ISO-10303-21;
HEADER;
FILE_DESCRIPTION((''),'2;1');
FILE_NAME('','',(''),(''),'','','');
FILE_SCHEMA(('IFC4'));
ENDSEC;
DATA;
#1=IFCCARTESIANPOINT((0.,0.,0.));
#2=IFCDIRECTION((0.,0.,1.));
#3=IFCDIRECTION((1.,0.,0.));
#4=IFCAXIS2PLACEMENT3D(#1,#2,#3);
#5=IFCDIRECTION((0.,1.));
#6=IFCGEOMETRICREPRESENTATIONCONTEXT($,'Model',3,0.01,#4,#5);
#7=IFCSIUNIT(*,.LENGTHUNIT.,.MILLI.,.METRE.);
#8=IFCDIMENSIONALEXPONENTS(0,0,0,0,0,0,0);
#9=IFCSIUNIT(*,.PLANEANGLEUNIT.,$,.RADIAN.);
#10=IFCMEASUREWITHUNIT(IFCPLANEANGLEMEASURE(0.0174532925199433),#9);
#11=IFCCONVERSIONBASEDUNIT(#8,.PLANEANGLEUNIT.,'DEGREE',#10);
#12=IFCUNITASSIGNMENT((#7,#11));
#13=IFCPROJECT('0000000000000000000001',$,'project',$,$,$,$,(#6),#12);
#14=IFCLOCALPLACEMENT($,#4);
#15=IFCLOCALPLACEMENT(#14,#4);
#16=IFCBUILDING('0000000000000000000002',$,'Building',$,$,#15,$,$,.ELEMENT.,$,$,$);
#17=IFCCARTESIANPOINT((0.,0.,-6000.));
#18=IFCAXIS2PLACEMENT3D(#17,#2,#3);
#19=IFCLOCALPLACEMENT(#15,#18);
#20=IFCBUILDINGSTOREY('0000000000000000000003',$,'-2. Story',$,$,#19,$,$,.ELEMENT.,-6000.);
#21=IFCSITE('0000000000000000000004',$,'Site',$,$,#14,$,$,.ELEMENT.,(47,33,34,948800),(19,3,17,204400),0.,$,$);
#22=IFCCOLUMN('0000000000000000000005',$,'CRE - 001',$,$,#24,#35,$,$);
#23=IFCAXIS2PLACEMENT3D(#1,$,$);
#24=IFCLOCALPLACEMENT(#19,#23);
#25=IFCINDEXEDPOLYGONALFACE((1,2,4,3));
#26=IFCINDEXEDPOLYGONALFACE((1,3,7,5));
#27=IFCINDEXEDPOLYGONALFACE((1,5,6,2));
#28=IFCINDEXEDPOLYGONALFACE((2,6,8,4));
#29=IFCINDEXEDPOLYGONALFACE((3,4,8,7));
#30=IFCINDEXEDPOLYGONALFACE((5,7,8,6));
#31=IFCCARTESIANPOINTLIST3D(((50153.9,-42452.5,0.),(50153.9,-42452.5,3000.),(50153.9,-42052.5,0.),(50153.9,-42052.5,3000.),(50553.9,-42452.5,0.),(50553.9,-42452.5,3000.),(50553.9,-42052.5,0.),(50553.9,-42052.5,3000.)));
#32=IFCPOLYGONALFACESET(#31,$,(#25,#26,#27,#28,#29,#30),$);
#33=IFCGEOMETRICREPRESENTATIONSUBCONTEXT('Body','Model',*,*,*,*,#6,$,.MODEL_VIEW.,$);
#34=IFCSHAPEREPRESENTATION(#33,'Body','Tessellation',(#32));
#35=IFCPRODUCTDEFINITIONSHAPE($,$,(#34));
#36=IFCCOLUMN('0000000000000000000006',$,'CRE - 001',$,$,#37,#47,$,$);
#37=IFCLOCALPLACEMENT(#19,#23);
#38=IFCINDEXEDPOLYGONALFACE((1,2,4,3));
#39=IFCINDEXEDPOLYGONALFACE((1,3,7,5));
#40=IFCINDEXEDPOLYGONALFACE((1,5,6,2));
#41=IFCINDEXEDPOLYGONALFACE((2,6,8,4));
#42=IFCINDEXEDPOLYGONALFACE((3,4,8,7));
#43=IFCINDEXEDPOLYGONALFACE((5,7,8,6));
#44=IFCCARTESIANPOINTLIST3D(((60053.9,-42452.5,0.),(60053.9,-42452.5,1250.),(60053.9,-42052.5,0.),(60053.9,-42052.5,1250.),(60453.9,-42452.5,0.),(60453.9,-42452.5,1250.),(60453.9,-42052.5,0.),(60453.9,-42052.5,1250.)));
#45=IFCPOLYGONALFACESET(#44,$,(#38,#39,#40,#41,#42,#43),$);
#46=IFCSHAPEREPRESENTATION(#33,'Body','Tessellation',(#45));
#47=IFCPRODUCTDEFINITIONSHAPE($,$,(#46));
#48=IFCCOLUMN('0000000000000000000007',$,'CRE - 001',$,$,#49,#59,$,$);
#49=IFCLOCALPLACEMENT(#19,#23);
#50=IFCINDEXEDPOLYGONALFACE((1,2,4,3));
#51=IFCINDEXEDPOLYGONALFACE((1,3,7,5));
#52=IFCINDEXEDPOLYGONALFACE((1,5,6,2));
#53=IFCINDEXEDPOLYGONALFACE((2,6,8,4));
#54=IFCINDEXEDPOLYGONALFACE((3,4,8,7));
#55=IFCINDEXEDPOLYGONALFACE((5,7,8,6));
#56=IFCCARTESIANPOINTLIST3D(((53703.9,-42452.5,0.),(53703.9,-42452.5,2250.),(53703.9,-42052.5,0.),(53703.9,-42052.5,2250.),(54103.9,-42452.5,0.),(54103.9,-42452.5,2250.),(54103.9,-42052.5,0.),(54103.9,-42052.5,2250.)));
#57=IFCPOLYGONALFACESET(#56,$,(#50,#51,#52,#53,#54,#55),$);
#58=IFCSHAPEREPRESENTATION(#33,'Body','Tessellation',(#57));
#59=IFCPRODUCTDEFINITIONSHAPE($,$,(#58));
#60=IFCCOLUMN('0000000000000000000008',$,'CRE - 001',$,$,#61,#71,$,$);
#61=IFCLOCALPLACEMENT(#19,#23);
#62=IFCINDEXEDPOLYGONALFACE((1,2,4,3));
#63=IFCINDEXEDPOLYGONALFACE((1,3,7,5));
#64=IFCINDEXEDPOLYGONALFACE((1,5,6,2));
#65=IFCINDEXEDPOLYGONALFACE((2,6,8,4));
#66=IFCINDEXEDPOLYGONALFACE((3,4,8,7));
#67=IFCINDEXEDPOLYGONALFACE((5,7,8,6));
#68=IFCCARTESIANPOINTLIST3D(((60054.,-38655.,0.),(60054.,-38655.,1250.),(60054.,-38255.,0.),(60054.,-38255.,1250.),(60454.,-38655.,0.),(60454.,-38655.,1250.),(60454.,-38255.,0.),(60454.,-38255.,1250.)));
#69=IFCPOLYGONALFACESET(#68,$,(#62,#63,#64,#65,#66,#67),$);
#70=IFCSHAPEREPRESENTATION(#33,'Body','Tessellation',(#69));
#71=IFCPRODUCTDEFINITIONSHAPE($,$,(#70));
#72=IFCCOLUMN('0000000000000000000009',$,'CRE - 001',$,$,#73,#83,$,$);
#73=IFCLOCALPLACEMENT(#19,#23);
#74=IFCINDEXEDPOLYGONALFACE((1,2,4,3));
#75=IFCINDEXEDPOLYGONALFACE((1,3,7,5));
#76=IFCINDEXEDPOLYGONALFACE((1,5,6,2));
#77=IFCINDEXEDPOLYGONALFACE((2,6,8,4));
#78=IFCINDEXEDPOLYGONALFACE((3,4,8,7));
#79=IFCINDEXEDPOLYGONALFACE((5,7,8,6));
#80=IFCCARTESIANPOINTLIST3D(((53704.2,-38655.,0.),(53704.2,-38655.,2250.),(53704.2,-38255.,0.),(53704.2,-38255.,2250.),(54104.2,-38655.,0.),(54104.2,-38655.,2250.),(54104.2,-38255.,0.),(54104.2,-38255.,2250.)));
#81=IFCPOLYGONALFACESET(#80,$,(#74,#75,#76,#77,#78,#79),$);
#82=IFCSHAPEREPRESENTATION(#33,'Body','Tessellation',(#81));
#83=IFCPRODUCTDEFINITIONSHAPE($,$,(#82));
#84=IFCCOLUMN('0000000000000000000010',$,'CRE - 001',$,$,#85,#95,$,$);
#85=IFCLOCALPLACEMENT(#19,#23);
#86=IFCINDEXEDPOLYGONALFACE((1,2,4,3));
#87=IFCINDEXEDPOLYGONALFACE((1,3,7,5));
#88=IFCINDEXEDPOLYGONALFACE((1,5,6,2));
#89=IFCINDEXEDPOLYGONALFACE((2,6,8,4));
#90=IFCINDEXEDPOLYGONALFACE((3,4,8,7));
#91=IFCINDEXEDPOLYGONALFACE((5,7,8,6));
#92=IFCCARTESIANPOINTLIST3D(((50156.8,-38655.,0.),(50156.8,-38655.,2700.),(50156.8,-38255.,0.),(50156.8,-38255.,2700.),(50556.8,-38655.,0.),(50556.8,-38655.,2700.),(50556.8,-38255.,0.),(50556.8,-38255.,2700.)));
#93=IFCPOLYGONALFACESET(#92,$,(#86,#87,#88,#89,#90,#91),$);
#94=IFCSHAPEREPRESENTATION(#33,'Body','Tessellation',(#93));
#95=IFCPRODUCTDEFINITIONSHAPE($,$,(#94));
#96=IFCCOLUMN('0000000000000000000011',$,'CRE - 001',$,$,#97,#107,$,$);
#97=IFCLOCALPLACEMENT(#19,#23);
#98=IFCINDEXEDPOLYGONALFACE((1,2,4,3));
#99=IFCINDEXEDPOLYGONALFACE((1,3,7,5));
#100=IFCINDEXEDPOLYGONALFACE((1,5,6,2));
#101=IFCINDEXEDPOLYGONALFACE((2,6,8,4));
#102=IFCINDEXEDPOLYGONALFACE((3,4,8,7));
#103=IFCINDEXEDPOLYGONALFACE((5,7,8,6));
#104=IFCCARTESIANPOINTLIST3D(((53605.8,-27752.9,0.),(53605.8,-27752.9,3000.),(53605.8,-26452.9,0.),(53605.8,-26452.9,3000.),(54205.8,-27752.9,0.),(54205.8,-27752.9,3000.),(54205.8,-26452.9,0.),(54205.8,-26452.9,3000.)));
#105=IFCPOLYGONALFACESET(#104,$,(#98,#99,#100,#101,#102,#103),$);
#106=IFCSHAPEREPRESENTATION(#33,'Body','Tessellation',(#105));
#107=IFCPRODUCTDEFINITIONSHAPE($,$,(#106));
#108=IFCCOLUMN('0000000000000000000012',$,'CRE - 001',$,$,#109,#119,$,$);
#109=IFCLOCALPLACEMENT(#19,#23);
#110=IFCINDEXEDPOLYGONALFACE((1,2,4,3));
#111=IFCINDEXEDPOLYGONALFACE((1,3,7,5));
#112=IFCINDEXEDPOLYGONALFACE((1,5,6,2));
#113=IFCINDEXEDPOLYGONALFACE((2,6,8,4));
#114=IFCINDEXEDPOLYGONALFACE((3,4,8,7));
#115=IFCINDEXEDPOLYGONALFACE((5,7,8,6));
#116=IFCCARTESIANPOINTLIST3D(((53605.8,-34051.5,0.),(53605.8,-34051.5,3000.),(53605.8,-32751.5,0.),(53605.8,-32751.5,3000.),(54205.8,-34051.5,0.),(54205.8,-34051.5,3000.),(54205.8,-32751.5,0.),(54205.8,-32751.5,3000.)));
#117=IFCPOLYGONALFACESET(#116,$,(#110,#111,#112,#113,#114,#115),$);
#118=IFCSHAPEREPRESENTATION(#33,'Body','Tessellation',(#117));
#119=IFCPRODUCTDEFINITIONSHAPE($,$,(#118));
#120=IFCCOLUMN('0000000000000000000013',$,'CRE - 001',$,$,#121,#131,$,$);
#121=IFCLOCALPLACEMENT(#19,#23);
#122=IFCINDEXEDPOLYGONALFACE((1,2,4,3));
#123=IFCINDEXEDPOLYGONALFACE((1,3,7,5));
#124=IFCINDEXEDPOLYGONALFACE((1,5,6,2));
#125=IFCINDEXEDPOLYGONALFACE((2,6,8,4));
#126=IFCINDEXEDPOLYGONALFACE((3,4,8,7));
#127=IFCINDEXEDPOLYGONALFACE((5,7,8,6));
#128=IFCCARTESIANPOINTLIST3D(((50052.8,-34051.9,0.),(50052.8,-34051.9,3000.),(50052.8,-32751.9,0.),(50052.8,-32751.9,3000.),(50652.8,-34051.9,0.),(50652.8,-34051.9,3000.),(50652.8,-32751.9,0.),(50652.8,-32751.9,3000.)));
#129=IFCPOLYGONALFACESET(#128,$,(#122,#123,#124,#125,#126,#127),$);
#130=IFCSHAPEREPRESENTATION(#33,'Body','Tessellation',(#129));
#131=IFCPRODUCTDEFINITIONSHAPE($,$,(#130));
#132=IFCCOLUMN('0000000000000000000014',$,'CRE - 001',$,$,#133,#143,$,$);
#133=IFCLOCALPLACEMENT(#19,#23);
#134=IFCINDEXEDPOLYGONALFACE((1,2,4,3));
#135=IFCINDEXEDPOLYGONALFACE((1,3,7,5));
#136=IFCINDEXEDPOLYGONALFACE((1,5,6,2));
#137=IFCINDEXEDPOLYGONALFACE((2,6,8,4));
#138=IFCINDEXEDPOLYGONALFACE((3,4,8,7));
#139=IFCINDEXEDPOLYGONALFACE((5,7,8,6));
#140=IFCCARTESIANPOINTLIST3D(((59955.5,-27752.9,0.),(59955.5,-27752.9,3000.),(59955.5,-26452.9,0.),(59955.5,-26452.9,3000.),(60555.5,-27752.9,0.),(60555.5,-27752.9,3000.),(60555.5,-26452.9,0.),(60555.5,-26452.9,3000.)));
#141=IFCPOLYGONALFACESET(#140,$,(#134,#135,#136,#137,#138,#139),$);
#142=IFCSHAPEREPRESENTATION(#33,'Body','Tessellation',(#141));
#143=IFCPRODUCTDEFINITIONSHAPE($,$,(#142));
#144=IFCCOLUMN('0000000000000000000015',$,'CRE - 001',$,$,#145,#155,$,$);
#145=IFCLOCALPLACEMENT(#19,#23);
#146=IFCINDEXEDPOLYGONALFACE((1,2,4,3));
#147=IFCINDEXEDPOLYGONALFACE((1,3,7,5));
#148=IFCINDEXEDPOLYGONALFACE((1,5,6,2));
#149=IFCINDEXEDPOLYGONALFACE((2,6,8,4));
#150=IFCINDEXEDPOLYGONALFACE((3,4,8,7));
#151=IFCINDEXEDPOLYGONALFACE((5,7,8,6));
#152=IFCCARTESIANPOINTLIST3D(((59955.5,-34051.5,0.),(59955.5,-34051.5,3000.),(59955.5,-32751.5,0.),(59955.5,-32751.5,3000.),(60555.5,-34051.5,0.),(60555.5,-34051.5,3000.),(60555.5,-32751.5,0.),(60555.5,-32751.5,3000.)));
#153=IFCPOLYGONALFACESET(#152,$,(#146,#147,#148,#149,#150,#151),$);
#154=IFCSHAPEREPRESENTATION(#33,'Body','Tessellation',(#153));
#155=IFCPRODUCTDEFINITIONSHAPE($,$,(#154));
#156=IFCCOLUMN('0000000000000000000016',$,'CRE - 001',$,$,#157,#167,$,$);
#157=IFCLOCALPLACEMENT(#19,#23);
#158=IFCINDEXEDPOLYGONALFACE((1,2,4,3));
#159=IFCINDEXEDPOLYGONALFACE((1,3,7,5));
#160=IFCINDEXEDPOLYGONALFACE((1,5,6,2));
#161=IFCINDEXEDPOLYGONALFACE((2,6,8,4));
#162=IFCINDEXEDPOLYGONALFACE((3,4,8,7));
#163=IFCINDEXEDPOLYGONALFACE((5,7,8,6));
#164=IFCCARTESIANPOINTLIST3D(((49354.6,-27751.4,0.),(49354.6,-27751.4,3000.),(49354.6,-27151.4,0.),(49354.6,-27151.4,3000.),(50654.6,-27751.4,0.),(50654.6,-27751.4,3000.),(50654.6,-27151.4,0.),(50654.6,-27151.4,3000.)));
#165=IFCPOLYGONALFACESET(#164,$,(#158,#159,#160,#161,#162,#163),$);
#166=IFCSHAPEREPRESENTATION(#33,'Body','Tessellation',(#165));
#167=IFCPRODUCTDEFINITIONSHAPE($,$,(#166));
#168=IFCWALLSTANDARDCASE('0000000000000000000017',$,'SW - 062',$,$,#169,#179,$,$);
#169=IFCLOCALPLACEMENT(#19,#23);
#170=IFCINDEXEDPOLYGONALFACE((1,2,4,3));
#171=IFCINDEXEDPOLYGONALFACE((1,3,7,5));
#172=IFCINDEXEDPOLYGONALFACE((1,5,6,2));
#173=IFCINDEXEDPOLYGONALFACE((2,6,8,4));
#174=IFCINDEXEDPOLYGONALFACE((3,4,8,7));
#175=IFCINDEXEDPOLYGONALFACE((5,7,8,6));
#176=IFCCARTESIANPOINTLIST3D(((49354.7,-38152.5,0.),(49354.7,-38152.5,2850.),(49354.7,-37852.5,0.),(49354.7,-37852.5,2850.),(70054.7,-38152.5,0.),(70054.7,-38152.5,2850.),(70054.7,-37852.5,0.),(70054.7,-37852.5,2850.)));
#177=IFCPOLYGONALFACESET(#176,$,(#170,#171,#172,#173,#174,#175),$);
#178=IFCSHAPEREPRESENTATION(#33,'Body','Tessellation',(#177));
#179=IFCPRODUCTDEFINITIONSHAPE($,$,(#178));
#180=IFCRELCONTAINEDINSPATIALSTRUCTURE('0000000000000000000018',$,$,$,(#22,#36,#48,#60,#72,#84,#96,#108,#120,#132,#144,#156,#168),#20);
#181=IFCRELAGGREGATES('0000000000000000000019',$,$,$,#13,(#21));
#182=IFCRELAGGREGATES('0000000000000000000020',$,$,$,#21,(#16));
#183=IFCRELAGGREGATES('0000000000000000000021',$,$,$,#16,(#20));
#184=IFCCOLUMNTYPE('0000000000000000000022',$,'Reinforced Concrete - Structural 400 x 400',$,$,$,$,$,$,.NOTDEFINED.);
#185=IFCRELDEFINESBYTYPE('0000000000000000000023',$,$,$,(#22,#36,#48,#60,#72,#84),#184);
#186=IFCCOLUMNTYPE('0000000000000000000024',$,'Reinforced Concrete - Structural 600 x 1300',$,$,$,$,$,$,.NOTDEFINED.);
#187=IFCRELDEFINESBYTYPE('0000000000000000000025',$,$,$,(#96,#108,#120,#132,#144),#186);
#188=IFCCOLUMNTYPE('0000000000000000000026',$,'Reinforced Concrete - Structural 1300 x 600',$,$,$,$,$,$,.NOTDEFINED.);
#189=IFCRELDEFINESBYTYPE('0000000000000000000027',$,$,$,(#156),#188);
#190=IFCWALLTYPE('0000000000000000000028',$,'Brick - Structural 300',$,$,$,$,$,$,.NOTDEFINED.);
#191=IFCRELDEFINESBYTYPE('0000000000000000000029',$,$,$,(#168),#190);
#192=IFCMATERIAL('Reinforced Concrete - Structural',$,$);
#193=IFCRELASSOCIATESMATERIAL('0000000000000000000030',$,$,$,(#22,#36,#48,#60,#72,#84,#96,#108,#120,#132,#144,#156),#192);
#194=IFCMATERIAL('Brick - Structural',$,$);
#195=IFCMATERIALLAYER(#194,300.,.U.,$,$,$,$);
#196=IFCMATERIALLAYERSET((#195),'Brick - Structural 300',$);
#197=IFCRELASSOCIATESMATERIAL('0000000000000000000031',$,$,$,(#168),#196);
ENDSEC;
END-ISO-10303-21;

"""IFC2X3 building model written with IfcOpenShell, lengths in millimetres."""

from ifc_helpers import new_model, entity, si_unit, converted_unit, direction, frame, origin_with_axes, origin_2d_with_axis, place, context, subcontext, project, spatial, polyline, rectangle, outline, extrude, material, layer, layer_set, layer_usage, type_object, element, save


model = new_model("IFC2X3")

# Units and contexts
model_context = context("Model", 3, precision=0.01, world=origin_with_axes(), true_north=direction((0.0, 1.0)))
body_context = subcontext(model_context, "Body", "Model", "MODEL_VIEW")
ifc_project = project(units=[si_unit("LENGTHUNIT", "METRE", prefix="MILLI"), converted_unit("PLANEANGLEUNIT", "DEGREE", entity("IfcPlaneAngleMeasure", 0.0174532925199433), si_unit("PLANEANGLEUNIT", "RADIAN"), dimensions=[0, 0, 0, 0, 0, 0, 0])], contexts=[model_context])

# Site, building, storey
site_placement = place(None, origin_with_axes())
site = spatial("IfcSite", under=ifc_project, at=site_placement, Name="Site", CompositionType="ELEMENT", RefLatitude=(47, 33, 34, 948800), RefLongitude=(19, 3, 17, 204400), RefElevation=0.0)
building_placement = place(site_placement, origin_with_axes())
building = spatial("IfcBuilding", under=site, at=building_placement, Name="Building", CompositionType="ELEMENT")
storey_placement = place(building_placement, frame((0.0, 0.0, -6000.0), z_axis=(0.0, 0.0, 1.0), x_axis=(1.0, 0.0, 0.0)))
storey = spatial("IfcBuildingStorey", under=building, at=storey_placement, Name="-2. Story", CompositionType="ELEMENT", Elevation=-6000.0)

# Columns
ifc_material_1 = material(Name="Reinforced Concrete - Structural")
column_type_1 = type_object("IfcColumnType", Name="Reinforced Concrete - Structural 400 x 400", PredefinedType="NOTDEFINED")
column_1_placement = place(storey_placement, frame((50353.9, -42252.5, 0.0), z_axis=(0.0, 0.0, 1.0), x_axis=(1.0, 0.0, 0.0)))
element("IfcColumn", 1, at=column_1_placement, inside=storey, type_object=column_type_1, material=ifc_material_1, Name="CRE - 001", context=body_context, shape_type="SweptSolid", body=[
    extrude(rectangle(XDim=400.0, YDim=400.0, at=origin_2d_with_axis()), origin_with_axes(), (0.0, 0.0, 1.0), 3000.0),
])
column_2_placement = place(storey_placement, frame((60253.9, -42252.5, 0.0), z_axis=(0.0, 0.0, 1.0), x_axis=(1.0, 0.0, 0.0)))
element("IfcColumn", 2, at=column_2_placement, inside=storey, type_object=column_type_1, material=ifc_material_1, Name="CRE - 001", context=body_context, shape_type="SweptSolid", body=[
    extrude(rectangle(XDim=400.0, YDim=400.0, at=origin_2d_with_axis()), origin_with_axes(), (0.0, 0.0, 1.0), 1250.0),
])
column_3_placement = place(storey_placement, frame((53903.9, -42252.5, 0.0), z_axis=(0.0, 0.0, 1.0), x_axis=(1.0, 0.0, 0.0)))
element("IfcColumn", 3, at=column_3_placement, inside=storey, type_object=column_type_1, material=ifc_material_1, Name="CRE - 001", context=body_context, shape_type="SweptSolid", body=[
    extrude(rectangle(XDim=400.0, YDim=400.0, at=origin_2d_with_axis()), origin_with_axes(), (0.0, 0.0, 1.0), 2250.0),
])
column_4_placement = place(storey_placement, frame((60254.0, -38455.0, 0.0), z_axis=(0.0, 0.0, 1.0), x_axis=(1.0, 0.0, 0.0)))
element("IfcColumn", 4, at=column_4_placement, inside=storey, type_object=column_type_1, material=ifc_material_1, Name="CRE - 001", context=body_context, shape_type="SweptSolid", body=[
    extrude(rectangle(XDim=400.0, YDim=400.0, at=origin_2d_with_axis()), origin_with_axes(), (0.0, 0.0, 1.0), 1250.0),
])
column_5_placement = place(storey_placement, frame((53904.2, -38455.0, 0.0), z_axis=(0.0, 0.0, 1.0), x_axis=(1.0, 0.0, 0.0)))
element("IfcColumn", 5, at=column_5_placement, inside=storey, type_object=column_type_1, material=ifc_material_1, Name="CRE - 001", context=body_context, shape_type="SweptSolid", body=[
    extrude(rectangle(XDim=400.0, YDim=400.0, at=origin_2d_with_axis()), origin_with_axes(), (0.0, 0.0, 1.0), 2250.0),
])
column_6_placement = place(storey_placement, frame((50356.8, -38455.0, 0.0), z_axis=(0.0, 0.0, 1.0), x_axis=(1.0, 0.0, 0.0)))
element("IfcColumn", 6, at=column_6_placement, inside=storey, type_object=column_type_1, material=ifc_material_1, Name="CRE - 001", context=body_context, shape_type="SweptSolid", body=[
    extrude(rectangle(XDim=400.0, YDim=400.0, at=origin_2d_with_axis()), origin_with_axes(), (0.0, 0.0, 1.0), 2700.0),
])
column_type_2 = type_object("IfcColumnType", Name="Reinforced Concrete - Structural 600 x 1300", PredefinedType="NOTDEFINED")
for number, where, z_axis, x_axis, name in (
    (7, (53905.8, -27102.9, 0.0), (0.0, 0.0, 1.0), (1.0, 0.0, 0.0), "CRE - 001"),
    (8, (53905.8, -33401.5, 0.0), (0.0, 0.0, 1.0), (1.0, 0.0, 0.0), "CRE - 001"),
    (9, (50352.8, -33401.9, 0.0), (0.0, 0.0, 1.0), (1.0, 0.0, 0.0), "CRE - 001"),
    (10, (60255.5, -27102.9, 0.0), (0.0, 0.0, 1.0), (1.0, 0.0, 0.0), "CRE - 001"),
    (11, (60255.5, -33401.5, 0.0), (0.0, 0.0, 1.0), (1.0, 0.0, 0.0), "CRE - 001"),
):
    element("IfcColumn", number, at=place(storey_placement, frame(where, z_axis=z_axis, x_axis=x_axis)), inside=storey, type_object=column_type_2, material=ifc_material_1, Name=name, context=body_context, shape_type="SweptSolid", body=[
        extrude(rectangle(XDim=600.0, YDim=1300.0, at=origin_2d_with_axis()), origin_with_axes(), (0.0, 0.0, 1.0), 3000.0),
    ])
column_type_3 = type_object("IfcColumnType", Name="Reinforced Concrete - Structural 1300 x 600", PredefinedType="NOTDEFINED")
column_7_placement = place(storey_placement, frame((50004.6, -27451.4, 0.0), z_axis=(0.0, 0.0, 1.0), x_axis=(1.0, 0.0, 0.0)))
element("IfcColumn", 12, at=column_7_placement, inside=storey, type_object=column_type_3, material=ifc_material_1, Name="CRE - 001", context=body_context, shape_type="SweptSolid", body=[
    extrude(rectangle(XDim=1300.0, YDim=600.0, at=origin_2d_with_axis()), origin_with_axes(), (0.0, 0.0, 1.0), 3000.0),
])

# Wall
ifc_material_2 = material(Name="Brick - Structural")
ifc_layer_1 = layer(ifc_material_2, 300.0, ventilated="UNKNOWN")
ifc_layer_set_1 = layer_set([ifc_layer_1], Name="Brick - Structural 300")
ifc_layer_usage_1 = layer_usage(ifc_layer_set_1, "AXIS2", "POSITIVE", 0.0)
wall_type_1 = type_object("IfcWallType", Name="Brick - Structural 300", PredefinedType="NOTDEFINED")
wall_1_placement = place(storey_placement, frame((49354.7, -38152.5, 0.0), z_axis=(0.0, 0.0, 1.0), x_axis=(1.0, 0.0, 0.0)))
element("IfcWallStandardCase", 13, at=wall_1_placement, inside=storey, type_object=wall_type_1, material=ifc_layer_usage_1, Name="SW - 062", context=body_context, shape_type="SweptSolid", body=[
    extrude(outline(polyline([(0.0, 0.0), (20700.0, 0.0), (20700.0, 300.0), (0.0, 300.0), (0.0, 0.0)])), origin_with_axes(), (0.0, 0.0, 1.0), 2850.0),
])

save(model, "model.ifc")
